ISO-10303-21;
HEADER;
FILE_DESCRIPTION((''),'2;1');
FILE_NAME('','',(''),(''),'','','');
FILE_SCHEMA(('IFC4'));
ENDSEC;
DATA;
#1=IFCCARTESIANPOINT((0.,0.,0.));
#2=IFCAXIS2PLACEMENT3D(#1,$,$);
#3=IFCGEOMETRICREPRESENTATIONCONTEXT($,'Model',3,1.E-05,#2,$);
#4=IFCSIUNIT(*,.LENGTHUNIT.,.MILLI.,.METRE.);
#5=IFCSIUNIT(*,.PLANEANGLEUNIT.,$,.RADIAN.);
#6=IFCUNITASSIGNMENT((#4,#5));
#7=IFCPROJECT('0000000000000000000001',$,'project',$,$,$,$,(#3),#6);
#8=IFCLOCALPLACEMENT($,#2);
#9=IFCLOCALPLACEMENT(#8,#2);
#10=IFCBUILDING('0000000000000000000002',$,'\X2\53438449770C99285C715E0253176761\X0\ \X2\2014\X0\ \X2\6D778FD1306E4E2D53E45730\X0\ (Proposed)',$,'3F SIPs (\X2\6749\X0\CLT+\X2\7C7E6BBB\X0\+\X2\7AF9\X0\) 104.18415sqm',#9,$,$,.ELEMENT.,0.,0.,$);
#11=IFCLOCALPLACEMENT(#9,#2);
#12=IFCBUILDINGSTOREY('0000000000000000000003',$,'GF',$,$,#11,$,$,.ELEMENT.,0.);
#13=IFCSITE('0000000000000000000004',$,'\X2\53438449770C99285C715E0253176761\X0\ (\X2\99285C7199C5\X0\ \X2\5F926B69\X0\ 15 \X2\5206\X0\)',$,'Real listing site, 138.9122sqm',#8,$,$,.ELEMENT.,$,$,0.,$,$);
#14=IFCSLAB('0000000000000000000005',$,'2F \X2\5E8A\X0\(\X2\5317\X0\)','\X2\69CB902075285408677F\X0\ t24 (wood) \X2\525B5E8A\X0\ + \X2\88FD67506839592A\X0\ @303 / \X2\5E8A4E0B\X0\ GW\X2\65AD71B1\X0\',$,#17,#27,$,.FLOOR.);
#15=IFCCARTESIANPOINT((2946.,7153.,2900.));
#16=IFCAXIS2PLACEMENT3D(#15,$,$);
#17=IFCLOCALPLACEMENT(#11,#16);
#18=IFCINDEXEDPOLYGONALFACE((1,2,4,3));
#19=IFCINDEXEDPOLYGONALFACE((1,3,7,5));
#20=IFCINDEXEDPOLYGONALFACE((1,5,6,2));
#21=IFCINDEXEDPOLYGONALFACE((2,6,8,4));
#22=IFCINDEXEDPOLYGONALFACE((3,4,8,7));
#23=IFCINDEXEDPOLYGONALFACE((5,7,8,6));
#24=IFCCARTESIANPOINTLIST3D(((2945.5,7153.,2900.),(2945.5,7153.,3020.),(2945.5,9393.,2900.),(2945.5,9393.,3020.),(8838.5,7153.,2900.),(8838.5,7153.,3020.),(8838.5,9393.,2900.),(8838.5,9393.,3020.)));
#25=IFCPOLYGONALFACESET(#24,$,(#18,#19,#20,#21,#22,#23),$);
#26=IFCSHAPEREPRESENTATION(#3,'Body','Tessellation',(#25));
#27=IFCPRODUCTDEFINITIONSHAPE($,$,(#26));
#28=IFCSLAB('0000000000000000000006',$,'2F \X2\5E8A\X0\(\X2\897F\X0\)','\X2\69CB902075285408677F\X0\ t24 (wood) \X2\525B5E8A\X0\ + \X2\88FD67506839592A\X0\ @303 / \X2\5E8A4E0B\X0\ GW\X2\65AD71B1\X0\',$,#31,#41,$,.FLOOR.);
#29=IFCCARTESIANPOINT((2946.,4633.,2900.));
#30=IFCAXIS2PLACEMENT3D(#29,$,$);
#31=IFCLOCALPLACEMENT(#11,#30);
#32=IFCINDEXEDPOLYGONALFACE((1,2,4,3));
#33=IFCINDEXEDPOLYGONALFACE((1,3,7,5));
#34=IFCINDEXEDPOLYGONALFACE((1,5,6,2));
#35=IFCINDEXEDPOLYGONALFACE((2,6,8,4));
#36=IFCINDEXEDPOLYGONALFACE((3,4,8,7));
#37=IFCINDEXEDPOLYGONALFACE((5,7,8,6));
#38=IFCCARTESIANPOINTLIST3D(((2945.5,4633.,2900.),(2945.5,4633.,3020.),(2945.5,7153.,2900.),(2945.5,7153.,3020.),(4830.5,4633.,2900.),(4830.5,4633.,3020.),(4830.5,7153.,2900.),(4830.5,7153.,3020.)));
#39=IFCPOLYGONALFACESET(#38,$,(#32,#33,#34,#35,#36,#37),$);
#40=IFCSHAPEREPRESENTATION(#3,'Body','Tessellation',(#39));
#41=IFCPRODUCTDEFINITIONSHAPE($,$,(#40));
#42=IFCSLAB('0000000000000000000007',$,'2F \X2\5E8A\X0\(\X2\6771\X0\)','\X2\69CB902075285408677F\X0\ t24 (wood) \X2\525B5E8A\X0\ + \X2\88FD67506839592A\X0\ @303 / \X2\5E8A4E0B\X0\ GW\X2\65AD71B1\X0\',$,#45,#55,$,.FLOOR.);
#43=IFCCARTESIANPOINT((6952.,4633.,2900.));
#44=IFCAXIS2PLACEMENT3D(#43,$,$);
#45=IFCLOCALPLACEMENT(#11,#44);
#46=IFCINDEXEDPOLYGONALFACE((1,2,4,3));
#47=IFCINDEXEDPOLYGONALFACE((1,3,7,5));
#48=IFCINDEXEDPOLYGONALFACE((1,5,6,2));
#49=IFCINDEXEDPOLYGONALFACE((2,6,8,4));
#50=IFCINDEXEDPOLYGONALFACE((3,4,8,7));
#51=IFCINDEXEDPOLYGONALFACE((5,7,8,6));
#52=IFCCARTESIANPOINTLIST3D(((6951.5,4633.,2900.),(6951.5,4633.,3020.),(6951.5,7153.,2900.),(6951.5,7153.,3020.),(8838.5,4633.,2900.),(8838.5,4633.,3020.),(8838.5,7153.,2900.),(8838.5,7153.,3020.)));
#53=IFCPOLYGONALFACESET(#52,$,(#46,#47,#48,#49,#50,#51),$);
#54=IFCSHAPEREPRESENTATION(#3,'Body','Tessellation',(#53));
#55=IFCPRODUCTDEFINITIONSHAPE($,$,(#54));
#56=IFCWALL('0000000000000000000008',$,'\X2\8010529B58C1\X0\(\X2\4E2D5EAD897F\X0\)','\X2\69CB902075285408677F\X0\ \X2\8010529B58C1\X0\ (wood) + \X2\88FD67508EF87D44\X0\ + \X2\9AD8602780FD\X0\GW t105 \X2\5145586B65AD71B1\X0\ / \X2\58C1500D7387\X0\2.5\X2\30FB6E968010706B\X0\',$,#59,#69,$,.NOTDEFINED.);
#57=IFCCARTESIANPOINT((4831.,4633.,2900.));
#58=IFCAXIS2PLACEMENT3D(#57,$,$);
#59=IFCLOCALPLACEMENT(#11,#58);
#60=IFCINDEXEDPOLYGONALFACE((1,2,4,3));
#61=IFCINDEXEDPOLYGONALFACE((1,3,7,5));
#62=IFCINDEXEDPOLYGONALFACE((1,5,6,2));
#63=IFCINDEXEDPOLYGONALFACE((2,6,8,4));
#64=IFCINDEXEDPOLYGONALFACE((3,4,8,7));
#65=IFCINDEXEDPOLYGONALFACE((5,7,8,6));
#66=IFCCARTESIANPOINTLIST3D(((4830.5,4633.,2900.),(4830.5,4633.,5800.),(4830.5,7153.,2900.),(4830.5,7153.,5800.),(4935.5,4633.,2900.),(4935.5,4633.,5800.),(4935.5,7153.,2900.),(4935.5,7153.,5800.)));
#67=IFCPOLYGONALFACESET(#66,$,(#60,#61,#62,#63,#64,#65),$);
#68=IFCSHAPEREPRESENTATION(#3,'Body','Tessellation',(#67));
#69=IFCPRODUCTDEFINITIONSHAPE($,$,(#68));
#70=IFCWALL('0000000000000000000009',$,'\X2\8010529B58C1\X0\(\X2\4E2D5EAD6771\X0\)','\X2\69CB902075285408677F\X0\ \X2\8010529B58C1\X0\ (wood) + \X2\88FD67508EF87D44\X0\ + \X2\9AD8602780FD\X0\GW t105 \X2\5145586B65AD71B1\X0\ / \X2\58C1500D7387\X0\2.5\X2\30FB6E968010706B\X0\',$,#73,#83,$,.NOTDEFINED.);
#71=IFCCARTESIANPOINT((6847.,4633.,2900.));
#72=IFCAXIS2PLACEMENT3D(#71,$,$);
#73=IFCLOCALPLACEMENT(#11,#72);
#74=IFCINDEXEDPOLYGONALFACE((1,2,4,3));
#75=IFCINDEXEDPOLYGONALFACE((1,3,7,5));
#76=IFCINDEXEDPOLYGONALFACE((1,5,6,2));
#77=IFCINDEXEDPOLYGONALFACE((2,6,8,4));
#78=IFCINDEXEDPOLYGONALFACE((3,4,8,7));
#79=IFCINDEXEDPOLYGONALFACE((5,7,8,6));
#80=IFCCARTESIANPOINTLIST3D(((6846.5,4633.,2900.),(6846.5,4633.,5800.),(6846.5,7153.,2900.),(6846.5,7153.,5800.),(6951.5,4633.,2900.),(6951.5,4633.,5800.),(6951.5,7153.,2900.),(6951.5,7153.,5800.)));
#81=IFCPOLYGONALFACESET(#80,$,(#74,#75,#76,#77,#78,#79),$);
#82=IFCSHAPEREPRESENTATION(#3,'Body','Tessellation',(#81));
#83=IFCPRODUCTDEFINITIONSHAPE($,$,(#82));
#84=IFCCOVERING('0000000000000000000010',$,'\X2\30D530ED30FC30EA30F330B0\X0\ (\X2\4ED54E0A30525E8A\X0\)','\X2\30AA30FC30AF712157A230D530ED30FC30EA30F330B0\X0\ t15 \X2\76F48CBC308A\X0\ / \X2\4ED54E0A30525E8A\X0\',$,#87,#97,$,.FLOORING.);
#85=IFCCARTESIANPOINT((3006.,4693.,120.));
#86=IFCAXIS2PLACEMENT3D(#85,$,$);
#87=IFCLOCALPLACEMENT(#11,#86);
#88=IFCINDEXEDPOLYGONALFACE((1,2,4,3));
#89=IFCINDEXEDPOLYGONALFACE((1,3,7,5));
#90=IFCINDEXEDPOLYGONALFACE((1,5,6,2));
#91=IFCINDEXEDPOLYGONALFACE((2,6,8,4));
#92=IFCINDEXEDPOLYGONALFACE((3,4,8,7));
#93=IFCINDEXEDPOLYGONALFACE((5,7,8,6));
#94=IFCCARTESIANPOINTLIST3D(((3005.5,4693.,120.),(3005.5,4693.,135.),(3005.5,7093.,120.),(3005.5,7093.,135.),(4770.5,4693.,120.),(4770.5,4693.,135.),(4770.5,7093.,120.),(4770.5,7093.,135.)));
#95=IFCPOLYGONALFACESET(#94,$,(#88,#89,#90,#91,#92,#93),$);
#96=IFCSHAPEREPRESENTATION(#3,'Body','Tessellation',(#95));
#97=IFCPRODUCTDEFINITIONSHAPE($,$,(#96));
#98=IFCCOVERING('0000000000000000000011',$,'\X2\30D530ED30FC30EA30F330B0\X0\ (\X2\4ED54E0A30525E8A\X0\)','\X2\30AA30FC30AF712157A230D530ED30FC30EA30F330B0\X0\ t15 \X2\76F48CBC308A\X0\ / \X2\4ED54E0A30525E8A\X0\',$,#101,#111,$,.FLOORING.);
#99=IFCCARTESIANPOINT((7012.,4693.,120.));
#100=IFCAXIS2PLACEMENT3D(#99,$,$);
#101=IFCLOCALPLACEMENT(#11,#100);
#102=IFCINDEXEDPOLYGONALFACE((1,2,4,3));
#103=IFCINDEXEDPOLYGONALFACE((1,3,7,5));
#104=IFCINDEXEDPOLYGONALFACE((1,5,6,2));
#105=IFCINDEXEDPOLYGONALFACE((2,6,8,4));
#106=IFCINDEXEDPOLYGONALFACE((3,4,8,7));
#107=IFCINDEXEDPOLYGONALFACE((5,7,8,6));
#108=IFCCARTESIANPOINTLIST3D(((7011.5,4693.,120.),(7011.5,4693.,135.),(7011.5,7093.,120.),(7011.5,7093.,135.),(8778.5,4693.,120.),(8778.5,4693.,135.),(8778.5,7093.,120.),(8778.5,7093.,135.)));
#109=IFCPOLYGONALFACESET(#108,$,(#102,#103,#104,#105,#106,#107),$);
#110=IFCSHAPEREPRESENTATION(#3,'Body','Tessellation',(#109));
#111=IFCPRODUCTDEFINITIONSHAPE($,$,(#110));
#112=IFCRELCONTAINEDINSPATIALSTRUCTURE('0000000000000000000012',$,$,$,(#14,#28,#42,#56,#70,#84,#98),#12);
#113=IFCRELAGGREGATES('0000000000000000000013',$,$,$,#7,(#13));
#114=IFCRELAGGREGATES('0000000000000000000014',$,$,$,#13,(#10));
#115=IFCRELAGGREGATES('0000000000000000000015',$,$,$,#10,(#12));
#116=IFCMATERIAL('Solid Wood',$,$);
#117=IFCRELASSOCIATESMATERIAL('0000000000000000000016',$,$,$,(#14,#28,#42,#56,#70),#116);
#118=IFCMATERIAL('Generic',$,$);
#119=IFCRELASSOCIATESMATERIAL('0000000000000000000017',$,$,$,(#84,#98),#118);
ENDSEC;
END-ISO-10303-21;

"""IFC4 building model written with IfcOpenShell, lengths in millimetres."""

from ifc_helpers import new_model, si_unit, frame, frame_2d, origin, place, context, project, spatial, rectangle, extrude, material, element, save


model = new_model("IFC4")

# Units and contexts
model_context = context("Model", 3, precision=1e-05, world=origin())
ifc_project = project(units=[si_unit("LENGTHUNIT", "METRE", prefix="MILLI"), si_unit("PLANEANGLEUNIT", "RADIAN")], contexts=[model_context])

# Site, building, storey
site_placement = place(None, origin())
site = spatial("IfcSite", under=ifc_project, at=site_placement, Name="千葉県館山市北条 (館山駅 徒歩 15 分)", ObjectType="Real listing site, 138.9122sqm", CompositionType="ELEMENT", RefElevation=0.0)
building_placement = place(site_placement, origin())
building = spatial("IfcBuilding", under=site, at=building_placement, Name="千葉県館山市北条 — 海近の中古地 (Proposed)", ObjectType="3F SIPs (杉CLT+籾殻+竹) 104.18415sqm", CompositionType="ELEMENT", ElevationOfRefHeight=0.0, ElevationOfTerrain=0.0)
storey_placement = place(building_placement, origin())
storey = spatial("IfcBuildingStorey", under=building, at=storey_placement, Name="GF", CompositionType="ELEMENT", Elevation=0.0)

# Slabs
ifc_material_1 = material(Name="Solid Wood")
slab_1_placement = place(storey_placement, frame((2946.0, 7153.0, 2900.0)))
element("IfcSlab", 1, at=slab_1_placement, inside=storey, material=ifc_material_1, Name="2F 床(北)", Description="構造用合板 t24 (wood) 剛床 + 製材根太 @303 / 床下 GW断熱", PredefinedType="FLOOR", context=model_context, shape_type="SweptSolid", body=[
    extrude(rectangle(XDim=5893.0, YDim=2240.0, at=frame_2d((2946.0, 1120.0))), frame((2946.0, 7153.0, 2900.0)), (0.0, 0.0, 1.0), 120.0),
])
slab_2_placement = place(storey_placement, frame((2946.0, 4633.0, 2900.0)))
element("IfcSlab", 2, at=slab_2_placement, inside=storey, material=ifc_material_1, Name="2F 床(西)", Description="構造用合板 t24 (wood) 剛床 + 製材根太 @303 / 床下 GW断熱", PredefinedType="FLOOR", context=model_context, shape_type="SweptSolid", body=[
    extrude(rectangle(XDim=1885.0, YDim=2520.0, at=frame_2d((942.0, 1260.0))), frame((2946.0, 4633.0, 2900.0)), (0.0, 0.0, 1.0), 120.0),
])
slab_3_placement = place(storey_placement, frame((6952.0, 4633.0, 2900.0)))
element("IfcSlab", 3, at=slab_3_placement, inside=storey, material=ifc_material_1, Name="2F 床(東)", Description="構造用合板 t24 (wood) 剛床 + 製材根太 @303 / 床下 GW断熱", PredefinedType="FLOOR", context=model_context, shape_type="SweptSolid", body=[
    extrude(rectangle(XDim=1887.0, YDim=2520.0, at=frame_2d((943.0, 1260.0))), frame((6952.0, 4633.0, 2900.0)), (0.0, 0.0, 1.0), 120.0),
])

# Walls
wall_1_placement = place(storey_placement, frame((4831.0, 4633.0, 2900.0)))
element("IfcWall", 4, at=wall_1_placement, inside=storey, material=ifc_material_1, Name="耐力壁(中庭西)", Description="構造用合板 耐力壁 (wood) + 製材軸組 + 高性能GW t105 充填断熱 / 壁倍率2.5・準耐火", PredefinedType="NOTDEFINED", context=model_context, shape_type="SweptSolid", body=[
    extrude(rectangle(XDim=105.0, YDim=2520.0, at=frame_2d((52.0, 1260.0))), frame((4831.0, 4633.0, 2900.0)), (0.0, 0.0, 1.0), 2900.0),
])
wall_2_placement = place(storey_placement, frame((6847.0, 4633.0, 2900.0)))
element("IfcWall", 5, at=wall_2_placement, inside=storey, material=ifc_material_1, Name="耐力壁(中庭東)", Description="構造用合板 耐力壁 (wood) + 製材軸組 + 高性能GW t105 充填断熱 / 壁倍率2.5・準耐火", PredefinedType="NOTDEFINED", context=model_context, shape_type="SweptSolid", body=[
    extrude(rectangle(XDim=105.0, YDim=2520.0, at=frame_2d((52.0, 1260.0))), frame((6847.0, 4633.0, 2900.0)), (0.0, 0.0, 1.0), 2900.0),
])

# Coverings
ifc_material_2 = material(Name="Generic")
covering_1_placement = place(storey_placement, frame((3006.0, 4693.0, 120.0)))
element("IfcCovering", 6, at=covering_1_placement, inside=storey, material=ifc_material_2, Name="フローリング (仕上げ床)", Description="オーク無垢フローリング t15 直貼り / 仕上げ床", PredefinedType="FLOORING", context=model_context, shape_type="SweptSolid", body=[
    extrude(rectangle(XDim=1765.0, YDim=2400.0, at=frame_2d((882.0, 1200.0))), frame((3006.0, 4693.0, 120.0)), (0.0, 0.0, 1.0), 15.0),
])
covering_2_placement = place(storey_placement, frame((7012.0, 4693.0, 120.0)))
element("IfcCovering", 7, at=covering_2_placement, inside=storey, material=ifc_material_2, Name="フローリング (仕上げ床)", Description="オーク無垢フローリング t15 直貼り / 仕上げ床", PredefinedType="FLOORING", context=model_context, shape_type="SweptSolid", body=[
    extrude(rectangle(XDim=1767.0, YDim=2400.0, at=frame_2d((883.0, 1200.0))), frame((7012.0, 4693.0, 120.0)), (0.0, 0.0, 1.0), 15.0),
])

save(model, "model.ifc")
